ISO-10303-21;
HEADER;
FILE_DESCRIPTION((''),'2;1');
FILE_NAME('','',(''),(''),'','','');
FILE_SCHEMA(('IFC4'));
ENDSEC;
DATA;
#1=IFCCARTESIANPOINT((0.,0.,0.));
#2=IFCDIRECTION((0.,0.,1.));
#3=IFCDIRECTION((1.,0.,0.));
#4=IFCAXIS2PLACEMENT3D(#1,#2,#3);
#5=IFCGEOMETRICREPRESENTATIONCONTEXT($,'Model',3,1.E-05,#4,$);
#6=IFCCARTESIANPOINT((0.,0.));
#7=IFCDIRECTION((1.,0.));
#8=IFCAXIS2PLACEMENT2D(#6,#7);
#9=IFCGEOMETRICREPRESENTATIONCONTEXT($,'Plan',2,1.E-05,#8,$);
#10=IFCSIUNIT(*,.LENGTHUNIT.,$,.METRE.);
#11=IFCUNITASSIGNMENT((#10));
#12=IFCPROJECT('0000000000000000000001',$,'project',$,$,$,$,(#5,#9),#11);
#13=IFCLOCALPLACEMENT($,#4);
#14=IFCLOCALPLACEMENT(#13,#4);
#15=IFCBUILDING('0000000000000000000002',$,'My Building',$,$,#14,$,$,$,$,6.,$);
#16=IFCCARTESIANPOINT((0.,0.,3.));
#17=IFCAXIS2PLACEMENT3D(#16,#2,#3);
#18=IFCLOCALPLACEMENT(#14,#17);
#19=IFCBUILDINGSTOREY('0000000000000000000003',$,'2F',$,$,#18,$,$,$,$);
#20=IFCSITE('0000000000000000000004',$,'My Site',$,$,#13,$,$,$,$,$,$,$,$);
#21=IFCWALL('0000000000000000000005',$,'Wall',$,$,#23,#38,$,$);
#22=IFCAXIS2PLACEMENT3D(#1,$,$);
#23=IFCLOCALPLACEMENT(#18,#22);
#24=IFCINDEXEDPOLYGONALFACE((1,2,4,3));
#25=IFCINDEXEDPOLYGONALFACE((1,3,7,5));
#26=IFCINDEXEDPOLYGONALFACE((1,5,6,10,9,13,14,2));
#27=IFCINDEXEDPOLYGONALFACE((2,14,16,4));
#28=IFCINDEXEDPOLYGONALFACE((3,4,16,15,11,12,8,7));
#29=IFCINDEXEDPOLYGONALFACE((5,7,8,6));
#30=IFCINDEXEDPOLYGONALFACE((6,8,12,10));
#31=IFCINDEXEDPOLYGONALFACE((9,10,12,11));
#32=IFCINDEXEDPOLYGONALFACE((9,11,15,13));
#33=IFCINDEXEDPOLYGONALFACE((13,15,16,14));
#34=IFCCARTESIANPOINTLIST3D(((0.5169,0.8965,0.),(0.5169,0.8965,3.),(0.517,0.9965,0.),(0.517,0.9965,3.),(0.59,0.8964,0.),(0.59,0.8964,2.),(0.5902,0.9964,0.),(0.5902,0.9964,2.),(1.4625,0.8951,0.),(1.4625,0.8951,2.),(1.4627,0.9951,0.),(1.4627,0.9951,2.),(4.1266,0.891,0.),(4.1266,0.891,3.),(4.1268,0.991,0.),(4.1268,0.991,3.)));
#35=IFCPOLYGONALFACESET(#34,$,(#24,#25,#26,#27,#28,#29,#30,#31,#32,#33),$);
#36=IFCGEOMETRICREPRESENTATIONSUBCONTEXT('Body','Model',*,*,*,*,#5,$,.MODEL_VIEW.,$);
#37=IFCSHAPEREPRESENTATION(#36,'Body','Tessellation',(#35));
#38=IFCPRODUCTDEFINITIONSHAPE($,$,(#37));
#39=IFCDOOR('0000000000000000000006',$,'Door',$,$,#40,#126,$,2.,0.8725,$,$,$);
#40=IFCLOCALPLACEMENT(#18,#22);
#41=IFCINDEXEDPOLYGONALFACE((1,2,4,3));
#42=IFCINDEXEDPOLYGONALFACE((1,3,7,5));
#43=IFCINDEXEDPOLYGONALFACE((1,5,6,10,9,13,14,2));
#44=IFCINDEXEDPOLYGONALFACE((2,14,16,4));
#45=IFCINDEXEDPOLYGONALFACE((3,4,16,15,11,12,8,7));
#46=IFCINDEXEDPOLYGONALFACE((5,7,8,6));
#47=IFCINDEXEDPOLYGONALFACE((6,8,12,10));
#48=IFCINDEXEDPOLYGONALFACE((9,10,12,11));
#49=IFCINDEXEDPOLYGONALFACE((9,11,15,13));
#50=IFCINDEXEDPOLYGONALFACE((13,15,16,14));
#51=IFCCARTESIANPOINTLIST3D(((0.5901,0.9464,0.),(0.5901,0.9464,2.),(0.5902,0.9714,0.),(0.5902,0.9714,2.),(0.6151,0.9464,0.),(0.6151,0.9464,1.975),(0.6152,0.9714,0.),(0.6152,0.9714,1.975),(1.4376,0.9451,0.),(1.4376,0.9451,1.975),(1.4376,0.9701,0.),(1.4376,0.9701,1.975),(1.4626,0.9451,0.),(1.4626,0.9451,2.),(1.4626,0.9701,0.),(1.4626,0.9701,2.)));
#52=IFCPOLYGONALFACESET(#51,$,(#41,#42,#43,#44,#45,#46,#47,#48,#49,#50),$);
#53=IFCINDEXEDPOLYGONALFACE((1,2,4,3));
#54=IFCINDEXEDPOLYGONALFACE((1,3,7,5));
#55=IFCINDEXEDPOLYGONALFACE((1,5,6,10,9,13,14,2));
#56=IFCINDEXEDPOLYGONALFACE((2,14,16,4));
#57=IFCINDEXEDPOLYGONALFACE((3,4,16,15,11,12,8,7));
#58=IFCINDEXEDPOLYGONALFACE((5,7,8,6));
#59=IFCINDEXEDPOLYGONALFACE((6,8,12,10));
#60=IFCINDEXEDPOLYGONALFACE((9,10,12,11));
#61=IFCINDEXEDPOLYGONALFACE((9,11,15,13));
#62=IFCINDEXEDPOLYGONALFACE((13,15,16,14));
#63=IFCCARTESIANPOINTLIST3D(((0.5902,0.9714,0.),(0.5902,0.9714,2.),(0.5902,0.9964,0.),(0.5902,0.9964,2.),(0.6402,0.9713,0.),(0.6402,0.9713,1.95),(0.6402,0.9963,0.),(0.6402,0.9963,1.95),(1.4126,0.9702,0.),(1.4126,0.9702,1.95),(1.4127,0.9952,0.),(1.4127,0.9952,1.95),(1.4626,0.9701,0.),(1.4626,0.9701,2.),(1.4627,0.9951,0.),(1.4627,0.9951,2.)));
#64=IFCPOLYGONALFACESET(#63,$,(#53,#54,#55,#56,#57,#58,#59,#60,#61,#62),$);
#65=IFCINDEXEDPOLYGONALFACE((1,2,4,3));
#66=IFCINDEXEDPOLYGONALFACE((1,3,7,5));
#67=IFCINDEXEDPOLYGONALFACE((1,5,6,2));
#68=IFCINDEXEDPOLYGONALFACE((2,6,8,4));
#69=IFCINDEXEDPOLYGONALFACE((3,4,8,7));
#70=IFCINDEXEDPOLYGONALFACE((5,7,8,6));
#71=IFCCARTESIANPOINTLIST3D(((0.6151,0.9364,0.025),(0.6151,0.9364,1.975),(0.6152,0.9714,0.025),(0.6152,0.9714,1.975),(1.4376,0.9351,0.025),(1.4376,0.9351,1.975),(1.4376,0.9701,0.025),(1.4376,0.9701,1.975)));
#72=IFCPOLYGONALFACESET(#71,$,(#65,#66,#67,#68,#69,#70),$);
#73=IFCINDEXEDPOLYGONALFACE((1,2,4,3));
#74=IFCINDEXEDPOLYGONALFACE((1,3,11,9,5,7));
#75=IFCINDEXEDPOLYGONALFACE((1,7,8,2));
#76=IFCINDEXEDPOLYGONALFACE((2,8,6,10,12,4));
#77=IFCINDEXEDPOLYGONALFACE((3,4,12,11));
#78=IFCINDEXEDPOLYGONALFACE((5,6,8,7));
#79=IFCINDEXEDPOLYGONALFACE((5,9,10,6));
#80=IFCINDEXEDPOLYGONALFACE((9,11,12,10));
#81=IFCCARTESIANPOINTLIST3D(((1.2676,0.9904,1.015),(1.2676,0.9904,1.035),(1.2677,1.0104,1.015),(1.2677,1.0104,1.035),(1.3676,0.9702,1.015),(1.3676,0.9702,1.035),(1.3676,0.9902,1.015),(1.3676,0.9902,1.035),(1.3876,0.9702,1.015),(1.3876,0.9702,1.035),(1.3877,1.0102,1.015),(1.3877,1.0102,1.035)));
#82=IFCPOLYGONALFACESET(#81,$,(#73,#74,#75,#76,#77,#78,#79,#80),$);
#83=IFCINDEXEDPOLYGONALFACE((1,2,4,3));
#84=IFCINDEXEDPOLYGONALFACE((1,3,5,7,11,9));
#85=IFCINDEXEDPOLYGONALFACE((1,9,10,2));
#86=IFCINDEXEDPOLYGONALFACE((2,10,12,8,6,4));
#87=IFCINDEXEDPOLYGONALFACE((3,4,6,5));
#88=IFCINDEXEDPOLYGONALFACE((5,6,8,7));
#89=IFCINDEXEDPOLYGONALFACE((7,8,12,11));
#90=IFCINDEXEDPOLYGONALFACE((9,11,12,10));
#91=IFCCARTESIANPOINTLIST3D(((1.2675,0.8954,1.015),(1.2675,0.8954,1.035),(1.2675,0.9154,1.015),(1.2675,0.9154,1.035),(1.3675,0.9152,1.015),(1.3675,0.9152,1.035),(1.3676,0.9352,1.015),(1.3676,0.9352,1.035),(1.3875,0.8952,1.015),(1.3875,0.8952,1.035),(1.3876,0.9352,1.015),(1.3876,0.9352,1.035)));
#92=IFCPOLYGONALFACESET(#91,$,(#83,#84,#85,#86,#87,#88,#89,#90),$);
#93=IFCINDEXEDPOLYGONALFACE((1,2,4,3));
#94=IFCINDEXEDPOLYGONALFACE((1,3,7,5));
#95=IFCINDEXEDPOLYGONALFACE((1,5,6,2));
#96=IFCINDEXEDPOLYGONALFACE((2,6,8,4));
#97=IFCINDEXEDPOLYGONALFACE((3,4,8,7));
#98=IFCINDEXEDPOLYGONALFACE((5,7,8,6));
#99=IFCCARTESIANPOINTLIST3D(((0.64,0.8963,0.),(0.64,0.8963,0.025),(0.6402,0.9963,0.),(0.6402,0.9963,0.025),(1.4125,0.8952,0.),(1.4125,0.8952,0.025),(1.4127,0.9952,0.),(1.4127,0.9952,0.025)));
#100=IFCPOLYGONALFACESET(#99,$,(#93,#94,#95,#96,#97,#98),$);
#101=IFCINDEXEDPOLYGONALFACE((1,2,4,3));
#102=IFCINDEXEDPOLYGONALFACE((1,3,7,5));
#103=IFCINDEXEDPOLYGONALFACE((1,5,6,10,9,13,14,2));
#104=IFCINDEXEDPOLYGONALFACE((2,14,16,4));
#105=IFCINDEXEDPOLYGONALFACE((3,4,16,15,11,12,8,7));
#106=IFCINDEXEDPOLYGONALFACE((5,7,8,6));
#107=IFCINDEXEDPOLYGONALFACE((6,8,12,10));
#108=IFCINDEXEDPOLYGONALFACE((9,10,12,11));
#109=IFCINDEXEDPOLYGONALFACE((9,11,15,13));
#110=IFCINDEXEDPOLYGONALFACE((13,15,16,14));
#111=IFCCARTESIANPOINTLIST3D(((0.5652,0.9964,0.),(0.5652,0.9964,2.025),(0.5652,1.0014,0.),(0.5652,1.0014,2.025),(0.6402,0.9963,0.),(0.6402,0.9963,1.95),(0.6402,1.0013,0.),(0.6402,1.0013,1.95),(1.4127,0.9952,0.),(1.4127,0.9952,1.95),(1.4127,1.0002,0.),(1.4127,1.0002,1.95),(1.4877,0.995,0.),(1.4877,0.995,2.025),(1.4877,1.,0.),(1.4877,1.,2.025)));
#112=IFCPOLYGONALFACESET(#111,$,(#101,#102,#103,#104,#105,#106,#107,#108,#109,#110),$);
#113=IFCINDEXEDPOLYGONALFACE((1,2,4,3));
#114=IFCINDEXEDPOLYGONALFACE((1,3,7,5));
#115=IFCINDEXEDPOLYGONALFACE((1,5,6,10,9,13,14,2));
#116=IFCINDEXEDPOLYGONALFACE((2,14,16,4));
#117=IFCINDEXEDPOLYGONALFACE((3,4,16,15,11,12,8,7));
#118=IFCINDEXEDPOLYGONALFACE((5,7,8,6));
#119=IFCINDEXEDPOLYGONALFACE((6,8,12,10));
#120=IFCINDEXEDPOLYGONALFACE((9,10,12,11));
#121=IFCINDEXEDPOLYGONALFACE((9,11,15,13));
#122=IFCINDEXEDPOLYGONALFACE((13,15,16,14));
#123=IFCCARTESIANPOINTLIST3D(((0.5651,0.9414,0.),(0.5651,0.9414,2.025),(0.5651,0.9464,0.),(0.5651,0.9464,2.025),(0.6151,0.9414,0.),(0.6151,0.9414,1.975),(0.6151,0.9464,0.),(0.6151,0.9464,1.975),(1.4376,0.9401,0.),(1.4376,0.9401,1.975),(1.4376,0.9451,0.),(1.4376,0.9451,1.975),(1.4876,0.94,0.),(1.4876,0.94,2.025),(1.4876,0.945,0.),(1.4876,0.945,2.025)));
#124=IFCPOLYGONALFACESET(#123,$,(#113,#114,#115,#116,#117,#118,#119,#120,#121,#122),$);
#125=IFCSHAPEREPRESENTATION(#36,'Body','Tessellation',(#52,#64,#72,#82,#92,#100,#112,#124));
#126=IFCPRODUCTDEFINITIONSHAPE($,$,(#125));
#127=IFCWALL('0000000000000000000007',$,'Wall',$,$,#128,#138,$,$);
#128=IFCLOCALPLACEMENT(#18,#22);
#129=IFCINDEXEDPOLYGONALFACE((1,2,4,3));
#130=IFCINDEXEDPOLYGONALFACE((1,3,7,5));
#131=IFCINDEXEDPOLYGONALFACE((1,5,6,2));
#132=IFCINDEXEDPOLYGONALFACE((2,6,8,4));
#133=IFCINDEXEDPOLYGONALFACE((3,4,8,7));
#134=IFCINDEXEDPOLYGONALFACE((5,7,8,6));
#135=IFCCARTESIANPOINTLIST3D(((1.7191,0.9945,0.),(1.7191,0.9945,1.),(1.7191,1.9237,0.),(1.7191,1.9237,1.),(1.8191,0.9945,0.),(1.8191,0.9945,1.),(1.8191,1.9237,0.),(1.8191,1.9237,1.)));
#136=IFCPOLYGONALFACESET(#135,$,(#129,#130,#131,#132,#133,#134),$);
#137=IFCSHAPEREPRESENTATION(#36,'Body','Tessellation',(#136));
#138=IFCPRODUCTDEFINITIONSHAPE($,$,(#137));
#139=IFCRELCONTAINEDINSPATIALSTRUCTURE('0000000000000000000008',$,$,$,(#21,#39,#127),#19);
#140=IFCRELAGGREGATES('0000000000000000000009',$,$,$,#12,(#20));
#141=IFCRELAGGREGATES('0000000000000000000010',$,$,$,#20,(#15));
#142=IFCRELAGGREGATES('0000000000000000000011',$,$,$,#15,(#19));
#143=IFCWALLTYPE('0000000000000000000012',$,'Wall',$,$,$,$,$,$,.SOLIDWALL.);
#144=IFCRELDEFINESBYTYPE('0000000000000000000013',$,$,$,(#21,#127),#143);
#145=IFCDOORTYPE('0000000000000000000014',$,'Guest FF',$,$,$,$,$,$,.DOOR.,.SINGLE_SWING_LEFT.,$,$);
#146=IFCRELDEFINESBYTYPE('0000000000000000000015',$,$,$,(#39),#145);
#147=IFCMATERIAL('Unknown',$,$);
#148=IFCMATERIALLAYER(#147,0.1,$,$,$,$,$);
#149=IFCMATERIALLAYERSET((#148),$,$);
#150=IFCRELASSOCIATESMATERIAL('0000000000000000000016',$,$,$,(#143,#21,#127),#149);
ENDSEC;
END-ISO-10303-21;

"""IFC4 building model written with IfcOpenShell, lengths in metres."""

from ifc_helpers import new_model, entity, si_unit, frame, origin_with_axes, origin_2d_with_axis, place, context, subcontext, project, spatial, line, indexed_curve, outline, extrude, shape, source, transform, mapped, material, layer, layer_set, layer_usage, type_object, type_shapes, element, fill, save


model = new_model("IFC4")

# Units and contexts
model_context = context("Model", 3, precision=1e-05, world=origin_with_axes())
plan_context = context("Plan", 2, precision=1e-05, world=origin_2d_with_axis())
body_context_1 = subcontext(model_context, "Body", "Model", "MODEL_VIEW")
body_context_2 = subcontext(plan_context, "Body", "Plan", "PLAN_VIEW")
ifc_project = project(units=[si_unit("LENGTHUNIT", "METRE")], contexts=[model_context, plan_context])

# Site, building, storey
site_placement = place(None, origin_with_axes())
site = spatial("IfcSite", under=ifc_project, at=site_placement, Name="My Site")
building_placement = place(site_placement, origin_with_axes())
building = spatial("IfcBuilding", under=site, at=building_placement, Name="My Building", ElevationOfTerrain=6.0)
storey_placement = place(building_placement, frame((0.0, 0.0, 3.0), z_axis=(0.0, 0.0, 1.0), x_axis=(1.0, 0.0, 0.0)))
storey = spatial("IfcBuildingStorey", under=building, at=storey_placement, Name="2F")

# Shared definitions
ifc_material_1 = material(Name="Unknown")

# Shared definitions
ifc_layer_1 = layer(ifc_material_1, 0.1)
ifc_layer_set_1 = layer_set([ifc_layer_1])
wall_type = type_object("IfcWallType", Name="Wall", PredefinedType="SOLIDWALL", material=ifc_layer_set_1)

# Shared definitions
shared_shape_1 = source(origin_with_axes(), body_context_1, "Body", "SweptSolid", [
    extrude(outline(indexed_curve([(0.0, 0.0), (0.8725, 0.0), (0.8725, 2.0), (0.0, 2.0)], segments=[line(1, 2, 3, 4, 1)])), frame((0.0, -0.6, 0.0), z_axis=(0.0, -1.0, 0.0), x_axis=(1.0, 0.0, 0.0)), (0.0, 0.0, -1.0), 1.2),
])
door_type_1 = type_object("IfcDoorType", Name="Guest FF", OperationType="SINGLE_SWING_LEFT", PredefinedType="DOOR")
shared_shape_2 = source(origin_with_axes(), body_context_1, "Body", "SweptSolid", [
    extrude(outline(indexed_curve([(0.0, 0.0), (0.0, 2.0), (0.8725, 2.0), (0.8725, 0.0), (0.8475, 0.0), (0.8475, 1.975), (0.025, 1.975), (0.025, 0.0)], segments=[line(1, 2, 3, 4, 5, 6, 7, 8, 1)])), frame((0.0, 0.025, 0.0), z_axis=(0.0, -1.0, 0.0), x_axis=(1.0, 0.0, 0.0)), (0.0, 0.0, -1.0), 0.025),
    extrude(outline(indexed_curve([(0.0, 0.0), (0.0, 2.0), (0.8725, 2.0), (0.8725, 0.0), (0.8225, 0.0), (0.8225, 1.95), (0.05, 1.95), (0.05, 0.0)], segments=[line(1, 2, 3, 4, 5, 6, 7, 8, 1)])), frame((0.0, 0.0, 0.0), z_axis=(0.0, -1.0, 0.0), x_axis=(1.0, 0.0, 0.0)), (0.0, 0.0, -1.0), 0.025),
    extrude(outline(indexed_curve([(0.0, 0.0), (0.8225, 0.0), (0.8225, 0.035), (0.0, 0.035)], segments=[line(1, 2, 3, 4, 1)])), frame((0.025, 0.025, 0.025), z_axis=(0.0, 0.0, 1.0), x_axis=(1.0, 0.0, 0.0)), (0.0, 0.0, 1.0), 1.95),
    extrude(outline(indexed_curve([(0.0, 0.0), (0.0, -0.04), (0.12, -0.04), (0.12, -0.02), (0.02, -0.02), (0.02, 0.0)], segments=[line(1, 2, 3, 4, 5, 6, 1)])), frame((0.075, 0.025, 1.015), z_axis=(0.0, 0.0, 1.0), x_axis=(1.0, 0.0, 0.0)), (0.0, 0.0, 1.0), 0.02),
    extrude(outline(indexed_curve([(0.0, 0.0), (0.0, 0.04), (0.12, 0.04), (0.12, 0.02), (0.02, 0.02), (0.02, 0.0)], segments=[line(1, 2, 3, 4, 5, 6, 1)])), frame((0.075, 0.06, 1.015), z_axis=(0.0, 0.0, 1.0), x_axis=(1.0, 0.0, 0.0)), (0.0, 0.0, 1.0), 0.02),
    extrude(outline(indexed_curve([(0.0, 0.0), (0.7725, 0.0), (0.7725, 0.1), (0.0, 0.1)], segments=[line(1, 2, 3, 4, 1)])), frame((0.05, 0.0, 0.0), z_axis=(0.0, 0.0, 1.0), x_axis=(1.0, 0.0, 0.0)), (0.0, 0.0, 1.0), 0.025),
    extrude(outline(indexed_curve([(0.0, 0.0), (0.0, 2.025), (0.9225, 2.025), (0.9225, 0.0), (0.8475, 0.0), (0.8475, 1.95), (0.075, 1.95), (0.075, 0.0)], segments=[line(1, 2, 3, 4, 5, 6, 7, 8, 1)])), frame((-0.025, -0.005, 0.0), z_axis=(0.0, -1.0, 0.0), x_axis=(1.0, 0.0, 0.0)), (0.0, 0.0, -1.0), 0.005),
    extrude(outline(indexed_curve([(0.0, 0.0), (0.0, 2.025), (0.9225, 2.025), (0.9225, 0.0), (0.8725, 0.0), (0.8725, 1.975), (0.05, 1.975), (0.05, 0.0)], segments=[line(1, 2, 3, 4, 5, 6, 7, 8, 1)])), frame((-0.025, 0.05, 0.0), z_axis=(0.0, -1.0, 0.0), x_axis=(1.0, 0.0, 0.0)), (0.0, 0.0, -1.0), 0.005),
])
shared_shape_3 = source(origin_with_axes(), body_context_2, "Body", "Curve2D", [
    entity("IfcIndexedPolyCurve", entity("IfcCartesianPointList2D", [[0.0, 0.0], [0.0, 0.05], [0.025, 0.05], [0.025, 0.025], [0.05, 0.025], [0.05, 0.0]]), [entity("IfcLineIndex", [1, 2, 3, 4, 5, 6, 1])]),
    entity("IfcIndexedPolyCurve", entity("IfcCartesianPointList2D", [[0.8725, 0.0], [0.8725, 0.05], [0.8475, 0.05], [0.8475, 0.025], [0.8225, 0.025], [0.8225, 0.0]]), [entity("IfcLineIndex", [1, 2, 3, 4, 5, 6, 1])]),
    entity("IfcTrimmedCurve", entity("IfcEllipse", entity("IfcAxis2Placement2D", entity("IfcCartesianPoint", [0.8125, 0.05]), entity("IfcDirection", [1.0, 0.0])), 0.7875, 0.8225), [entity("IfcCartesianPoint", [0.8125, 0.8725])], [entity("IfcCartesianPoint", [0.025, 0.05])], True, "CARTESIAN"),
    entity("IfcIndexedPolyCurve", entity("IfcCartesianPointList2D", [[0.8475, 0.05], [0.8125, 0.05], [0.8125, 0.8725], [0.8475, 0.8725]]), [entity("IfcLineIndex", [1, 2, 3, 4, 1])]),
])
type_shapes(door_type_1, [shared_shape_2, shared_shape_3])

# Wall, opening, door
ifc_layer_usage_1 = layer_usage(ifc_layer_set_1, "AXIS2", "POSITIVE", 0.0)
wall_1_placement = place(storey_placement, frame((0.5169, 0.8965, 0.0), z_axis=(0.0, 0.0, 1.0), x_axis=(0.999999, -0.001517, 0.0)))
wall_1 = element("IfcWall", 1, at=wall_1_placement, inside=storey, type_object=wall_type, material=ifc_layer_usage_1, Name="Wall", context=body_context_1, shape_type="SweptSolid", body=[
    extrude(outline(indexed_curve([(0.0, 0.0), (0.0, 0.1), (3.6097, 0.1), (3.6097, 0.0)], segments=[line(1, 2, 3, 4, 1)])), origin_with_axes(), (0.0, 0.0, 1.0), 3.0),
])
opening_1_placement = place(wall_1_placement, frame((0.9456, 0.1, 0.0), z_axis=(0.0, 0.0, 1.0), x_axis=(-1.0, 0.0, 0.0)))
opening_1 = element("IfcOpeningElement", 2, at=opening_1_placement, cuts=wall_1, PredefinedType="OPENING", context=body_context_1, shape_type="MappedRepresentation", body=[
    mapped(shared_shape_1, transform((0.0, 0.0, 0.0), x_axis=(1.0, 0.0, 0.0), y_axis=(0.0, 1.0, 0.0), z_axis=(0.0, 0.0, 1.0), scale=1.0)),
])
door_1_placement = place(opening_1_placement, frame((0.0, 0.0, 0.0), z_axis=(0.0, 0.0, 1.0), x_axis=(1.0, 0.0, 0.0)))
door_1 = element("IfcDoor", 3, at=door_1_placement, inside=storey, type_object=door_type_1, Name="Door", OverallHeight=2.0, OverallWidth=0.8725, shapes=[
    shape(body_context_1, "Body", "MappedRepresentation", [mapped(shared_shape_2, transform((0.0, 0.0, 0.0), x_axis=(1.0, 0.0, 0.0), y_axis=(0.0, 1.0, 0.0), z_axis=(0.0, 0.0, 1.0), scale=1.0))]),
    shape(body_context_2, "Body", "MappedRepresentation", [mapped(shared_shape_3, transform((0.0, 0.0, 0.0), x_axis=(1.0, 0.0, 0.0), y_axis=(0.0, 1.0, 0.0), z_axis=(0.0, 0.0, 1.0), scale=1.0))]),
])
fill(opening_1, door_1)

# Wall
ifc_layer_usage_2 = layer_usage(ifc_layer_set_1, "AXIS2", "POSITIVE", 0.0)
wall_2_placement = place(storey_placement, frame((1.8191, 0.9945, 0.0), z_axis=(0.0, 0.0, 1.0), x_axis=(0.0, 1.0, 0.0)))
element("IfcWall", 4, at=wall_2_placement, inside=storey, type_object=wall_type, material=ifc_layer_usage_2, Name="Wall", context=body_context_1, shape_type="SweptSolid", body=[
    extrude(outline(indexed_curve([(0.0, 0.0), (0.0, 0.1), (0.9291, 0.1), (0.9291, 0.0)], segments=[line(1, 2, 3, 4, 1)])), origin_with_axes(), (0.0, 0.0, 1.0), 1.0),
])

save(model, "model.ifc")
